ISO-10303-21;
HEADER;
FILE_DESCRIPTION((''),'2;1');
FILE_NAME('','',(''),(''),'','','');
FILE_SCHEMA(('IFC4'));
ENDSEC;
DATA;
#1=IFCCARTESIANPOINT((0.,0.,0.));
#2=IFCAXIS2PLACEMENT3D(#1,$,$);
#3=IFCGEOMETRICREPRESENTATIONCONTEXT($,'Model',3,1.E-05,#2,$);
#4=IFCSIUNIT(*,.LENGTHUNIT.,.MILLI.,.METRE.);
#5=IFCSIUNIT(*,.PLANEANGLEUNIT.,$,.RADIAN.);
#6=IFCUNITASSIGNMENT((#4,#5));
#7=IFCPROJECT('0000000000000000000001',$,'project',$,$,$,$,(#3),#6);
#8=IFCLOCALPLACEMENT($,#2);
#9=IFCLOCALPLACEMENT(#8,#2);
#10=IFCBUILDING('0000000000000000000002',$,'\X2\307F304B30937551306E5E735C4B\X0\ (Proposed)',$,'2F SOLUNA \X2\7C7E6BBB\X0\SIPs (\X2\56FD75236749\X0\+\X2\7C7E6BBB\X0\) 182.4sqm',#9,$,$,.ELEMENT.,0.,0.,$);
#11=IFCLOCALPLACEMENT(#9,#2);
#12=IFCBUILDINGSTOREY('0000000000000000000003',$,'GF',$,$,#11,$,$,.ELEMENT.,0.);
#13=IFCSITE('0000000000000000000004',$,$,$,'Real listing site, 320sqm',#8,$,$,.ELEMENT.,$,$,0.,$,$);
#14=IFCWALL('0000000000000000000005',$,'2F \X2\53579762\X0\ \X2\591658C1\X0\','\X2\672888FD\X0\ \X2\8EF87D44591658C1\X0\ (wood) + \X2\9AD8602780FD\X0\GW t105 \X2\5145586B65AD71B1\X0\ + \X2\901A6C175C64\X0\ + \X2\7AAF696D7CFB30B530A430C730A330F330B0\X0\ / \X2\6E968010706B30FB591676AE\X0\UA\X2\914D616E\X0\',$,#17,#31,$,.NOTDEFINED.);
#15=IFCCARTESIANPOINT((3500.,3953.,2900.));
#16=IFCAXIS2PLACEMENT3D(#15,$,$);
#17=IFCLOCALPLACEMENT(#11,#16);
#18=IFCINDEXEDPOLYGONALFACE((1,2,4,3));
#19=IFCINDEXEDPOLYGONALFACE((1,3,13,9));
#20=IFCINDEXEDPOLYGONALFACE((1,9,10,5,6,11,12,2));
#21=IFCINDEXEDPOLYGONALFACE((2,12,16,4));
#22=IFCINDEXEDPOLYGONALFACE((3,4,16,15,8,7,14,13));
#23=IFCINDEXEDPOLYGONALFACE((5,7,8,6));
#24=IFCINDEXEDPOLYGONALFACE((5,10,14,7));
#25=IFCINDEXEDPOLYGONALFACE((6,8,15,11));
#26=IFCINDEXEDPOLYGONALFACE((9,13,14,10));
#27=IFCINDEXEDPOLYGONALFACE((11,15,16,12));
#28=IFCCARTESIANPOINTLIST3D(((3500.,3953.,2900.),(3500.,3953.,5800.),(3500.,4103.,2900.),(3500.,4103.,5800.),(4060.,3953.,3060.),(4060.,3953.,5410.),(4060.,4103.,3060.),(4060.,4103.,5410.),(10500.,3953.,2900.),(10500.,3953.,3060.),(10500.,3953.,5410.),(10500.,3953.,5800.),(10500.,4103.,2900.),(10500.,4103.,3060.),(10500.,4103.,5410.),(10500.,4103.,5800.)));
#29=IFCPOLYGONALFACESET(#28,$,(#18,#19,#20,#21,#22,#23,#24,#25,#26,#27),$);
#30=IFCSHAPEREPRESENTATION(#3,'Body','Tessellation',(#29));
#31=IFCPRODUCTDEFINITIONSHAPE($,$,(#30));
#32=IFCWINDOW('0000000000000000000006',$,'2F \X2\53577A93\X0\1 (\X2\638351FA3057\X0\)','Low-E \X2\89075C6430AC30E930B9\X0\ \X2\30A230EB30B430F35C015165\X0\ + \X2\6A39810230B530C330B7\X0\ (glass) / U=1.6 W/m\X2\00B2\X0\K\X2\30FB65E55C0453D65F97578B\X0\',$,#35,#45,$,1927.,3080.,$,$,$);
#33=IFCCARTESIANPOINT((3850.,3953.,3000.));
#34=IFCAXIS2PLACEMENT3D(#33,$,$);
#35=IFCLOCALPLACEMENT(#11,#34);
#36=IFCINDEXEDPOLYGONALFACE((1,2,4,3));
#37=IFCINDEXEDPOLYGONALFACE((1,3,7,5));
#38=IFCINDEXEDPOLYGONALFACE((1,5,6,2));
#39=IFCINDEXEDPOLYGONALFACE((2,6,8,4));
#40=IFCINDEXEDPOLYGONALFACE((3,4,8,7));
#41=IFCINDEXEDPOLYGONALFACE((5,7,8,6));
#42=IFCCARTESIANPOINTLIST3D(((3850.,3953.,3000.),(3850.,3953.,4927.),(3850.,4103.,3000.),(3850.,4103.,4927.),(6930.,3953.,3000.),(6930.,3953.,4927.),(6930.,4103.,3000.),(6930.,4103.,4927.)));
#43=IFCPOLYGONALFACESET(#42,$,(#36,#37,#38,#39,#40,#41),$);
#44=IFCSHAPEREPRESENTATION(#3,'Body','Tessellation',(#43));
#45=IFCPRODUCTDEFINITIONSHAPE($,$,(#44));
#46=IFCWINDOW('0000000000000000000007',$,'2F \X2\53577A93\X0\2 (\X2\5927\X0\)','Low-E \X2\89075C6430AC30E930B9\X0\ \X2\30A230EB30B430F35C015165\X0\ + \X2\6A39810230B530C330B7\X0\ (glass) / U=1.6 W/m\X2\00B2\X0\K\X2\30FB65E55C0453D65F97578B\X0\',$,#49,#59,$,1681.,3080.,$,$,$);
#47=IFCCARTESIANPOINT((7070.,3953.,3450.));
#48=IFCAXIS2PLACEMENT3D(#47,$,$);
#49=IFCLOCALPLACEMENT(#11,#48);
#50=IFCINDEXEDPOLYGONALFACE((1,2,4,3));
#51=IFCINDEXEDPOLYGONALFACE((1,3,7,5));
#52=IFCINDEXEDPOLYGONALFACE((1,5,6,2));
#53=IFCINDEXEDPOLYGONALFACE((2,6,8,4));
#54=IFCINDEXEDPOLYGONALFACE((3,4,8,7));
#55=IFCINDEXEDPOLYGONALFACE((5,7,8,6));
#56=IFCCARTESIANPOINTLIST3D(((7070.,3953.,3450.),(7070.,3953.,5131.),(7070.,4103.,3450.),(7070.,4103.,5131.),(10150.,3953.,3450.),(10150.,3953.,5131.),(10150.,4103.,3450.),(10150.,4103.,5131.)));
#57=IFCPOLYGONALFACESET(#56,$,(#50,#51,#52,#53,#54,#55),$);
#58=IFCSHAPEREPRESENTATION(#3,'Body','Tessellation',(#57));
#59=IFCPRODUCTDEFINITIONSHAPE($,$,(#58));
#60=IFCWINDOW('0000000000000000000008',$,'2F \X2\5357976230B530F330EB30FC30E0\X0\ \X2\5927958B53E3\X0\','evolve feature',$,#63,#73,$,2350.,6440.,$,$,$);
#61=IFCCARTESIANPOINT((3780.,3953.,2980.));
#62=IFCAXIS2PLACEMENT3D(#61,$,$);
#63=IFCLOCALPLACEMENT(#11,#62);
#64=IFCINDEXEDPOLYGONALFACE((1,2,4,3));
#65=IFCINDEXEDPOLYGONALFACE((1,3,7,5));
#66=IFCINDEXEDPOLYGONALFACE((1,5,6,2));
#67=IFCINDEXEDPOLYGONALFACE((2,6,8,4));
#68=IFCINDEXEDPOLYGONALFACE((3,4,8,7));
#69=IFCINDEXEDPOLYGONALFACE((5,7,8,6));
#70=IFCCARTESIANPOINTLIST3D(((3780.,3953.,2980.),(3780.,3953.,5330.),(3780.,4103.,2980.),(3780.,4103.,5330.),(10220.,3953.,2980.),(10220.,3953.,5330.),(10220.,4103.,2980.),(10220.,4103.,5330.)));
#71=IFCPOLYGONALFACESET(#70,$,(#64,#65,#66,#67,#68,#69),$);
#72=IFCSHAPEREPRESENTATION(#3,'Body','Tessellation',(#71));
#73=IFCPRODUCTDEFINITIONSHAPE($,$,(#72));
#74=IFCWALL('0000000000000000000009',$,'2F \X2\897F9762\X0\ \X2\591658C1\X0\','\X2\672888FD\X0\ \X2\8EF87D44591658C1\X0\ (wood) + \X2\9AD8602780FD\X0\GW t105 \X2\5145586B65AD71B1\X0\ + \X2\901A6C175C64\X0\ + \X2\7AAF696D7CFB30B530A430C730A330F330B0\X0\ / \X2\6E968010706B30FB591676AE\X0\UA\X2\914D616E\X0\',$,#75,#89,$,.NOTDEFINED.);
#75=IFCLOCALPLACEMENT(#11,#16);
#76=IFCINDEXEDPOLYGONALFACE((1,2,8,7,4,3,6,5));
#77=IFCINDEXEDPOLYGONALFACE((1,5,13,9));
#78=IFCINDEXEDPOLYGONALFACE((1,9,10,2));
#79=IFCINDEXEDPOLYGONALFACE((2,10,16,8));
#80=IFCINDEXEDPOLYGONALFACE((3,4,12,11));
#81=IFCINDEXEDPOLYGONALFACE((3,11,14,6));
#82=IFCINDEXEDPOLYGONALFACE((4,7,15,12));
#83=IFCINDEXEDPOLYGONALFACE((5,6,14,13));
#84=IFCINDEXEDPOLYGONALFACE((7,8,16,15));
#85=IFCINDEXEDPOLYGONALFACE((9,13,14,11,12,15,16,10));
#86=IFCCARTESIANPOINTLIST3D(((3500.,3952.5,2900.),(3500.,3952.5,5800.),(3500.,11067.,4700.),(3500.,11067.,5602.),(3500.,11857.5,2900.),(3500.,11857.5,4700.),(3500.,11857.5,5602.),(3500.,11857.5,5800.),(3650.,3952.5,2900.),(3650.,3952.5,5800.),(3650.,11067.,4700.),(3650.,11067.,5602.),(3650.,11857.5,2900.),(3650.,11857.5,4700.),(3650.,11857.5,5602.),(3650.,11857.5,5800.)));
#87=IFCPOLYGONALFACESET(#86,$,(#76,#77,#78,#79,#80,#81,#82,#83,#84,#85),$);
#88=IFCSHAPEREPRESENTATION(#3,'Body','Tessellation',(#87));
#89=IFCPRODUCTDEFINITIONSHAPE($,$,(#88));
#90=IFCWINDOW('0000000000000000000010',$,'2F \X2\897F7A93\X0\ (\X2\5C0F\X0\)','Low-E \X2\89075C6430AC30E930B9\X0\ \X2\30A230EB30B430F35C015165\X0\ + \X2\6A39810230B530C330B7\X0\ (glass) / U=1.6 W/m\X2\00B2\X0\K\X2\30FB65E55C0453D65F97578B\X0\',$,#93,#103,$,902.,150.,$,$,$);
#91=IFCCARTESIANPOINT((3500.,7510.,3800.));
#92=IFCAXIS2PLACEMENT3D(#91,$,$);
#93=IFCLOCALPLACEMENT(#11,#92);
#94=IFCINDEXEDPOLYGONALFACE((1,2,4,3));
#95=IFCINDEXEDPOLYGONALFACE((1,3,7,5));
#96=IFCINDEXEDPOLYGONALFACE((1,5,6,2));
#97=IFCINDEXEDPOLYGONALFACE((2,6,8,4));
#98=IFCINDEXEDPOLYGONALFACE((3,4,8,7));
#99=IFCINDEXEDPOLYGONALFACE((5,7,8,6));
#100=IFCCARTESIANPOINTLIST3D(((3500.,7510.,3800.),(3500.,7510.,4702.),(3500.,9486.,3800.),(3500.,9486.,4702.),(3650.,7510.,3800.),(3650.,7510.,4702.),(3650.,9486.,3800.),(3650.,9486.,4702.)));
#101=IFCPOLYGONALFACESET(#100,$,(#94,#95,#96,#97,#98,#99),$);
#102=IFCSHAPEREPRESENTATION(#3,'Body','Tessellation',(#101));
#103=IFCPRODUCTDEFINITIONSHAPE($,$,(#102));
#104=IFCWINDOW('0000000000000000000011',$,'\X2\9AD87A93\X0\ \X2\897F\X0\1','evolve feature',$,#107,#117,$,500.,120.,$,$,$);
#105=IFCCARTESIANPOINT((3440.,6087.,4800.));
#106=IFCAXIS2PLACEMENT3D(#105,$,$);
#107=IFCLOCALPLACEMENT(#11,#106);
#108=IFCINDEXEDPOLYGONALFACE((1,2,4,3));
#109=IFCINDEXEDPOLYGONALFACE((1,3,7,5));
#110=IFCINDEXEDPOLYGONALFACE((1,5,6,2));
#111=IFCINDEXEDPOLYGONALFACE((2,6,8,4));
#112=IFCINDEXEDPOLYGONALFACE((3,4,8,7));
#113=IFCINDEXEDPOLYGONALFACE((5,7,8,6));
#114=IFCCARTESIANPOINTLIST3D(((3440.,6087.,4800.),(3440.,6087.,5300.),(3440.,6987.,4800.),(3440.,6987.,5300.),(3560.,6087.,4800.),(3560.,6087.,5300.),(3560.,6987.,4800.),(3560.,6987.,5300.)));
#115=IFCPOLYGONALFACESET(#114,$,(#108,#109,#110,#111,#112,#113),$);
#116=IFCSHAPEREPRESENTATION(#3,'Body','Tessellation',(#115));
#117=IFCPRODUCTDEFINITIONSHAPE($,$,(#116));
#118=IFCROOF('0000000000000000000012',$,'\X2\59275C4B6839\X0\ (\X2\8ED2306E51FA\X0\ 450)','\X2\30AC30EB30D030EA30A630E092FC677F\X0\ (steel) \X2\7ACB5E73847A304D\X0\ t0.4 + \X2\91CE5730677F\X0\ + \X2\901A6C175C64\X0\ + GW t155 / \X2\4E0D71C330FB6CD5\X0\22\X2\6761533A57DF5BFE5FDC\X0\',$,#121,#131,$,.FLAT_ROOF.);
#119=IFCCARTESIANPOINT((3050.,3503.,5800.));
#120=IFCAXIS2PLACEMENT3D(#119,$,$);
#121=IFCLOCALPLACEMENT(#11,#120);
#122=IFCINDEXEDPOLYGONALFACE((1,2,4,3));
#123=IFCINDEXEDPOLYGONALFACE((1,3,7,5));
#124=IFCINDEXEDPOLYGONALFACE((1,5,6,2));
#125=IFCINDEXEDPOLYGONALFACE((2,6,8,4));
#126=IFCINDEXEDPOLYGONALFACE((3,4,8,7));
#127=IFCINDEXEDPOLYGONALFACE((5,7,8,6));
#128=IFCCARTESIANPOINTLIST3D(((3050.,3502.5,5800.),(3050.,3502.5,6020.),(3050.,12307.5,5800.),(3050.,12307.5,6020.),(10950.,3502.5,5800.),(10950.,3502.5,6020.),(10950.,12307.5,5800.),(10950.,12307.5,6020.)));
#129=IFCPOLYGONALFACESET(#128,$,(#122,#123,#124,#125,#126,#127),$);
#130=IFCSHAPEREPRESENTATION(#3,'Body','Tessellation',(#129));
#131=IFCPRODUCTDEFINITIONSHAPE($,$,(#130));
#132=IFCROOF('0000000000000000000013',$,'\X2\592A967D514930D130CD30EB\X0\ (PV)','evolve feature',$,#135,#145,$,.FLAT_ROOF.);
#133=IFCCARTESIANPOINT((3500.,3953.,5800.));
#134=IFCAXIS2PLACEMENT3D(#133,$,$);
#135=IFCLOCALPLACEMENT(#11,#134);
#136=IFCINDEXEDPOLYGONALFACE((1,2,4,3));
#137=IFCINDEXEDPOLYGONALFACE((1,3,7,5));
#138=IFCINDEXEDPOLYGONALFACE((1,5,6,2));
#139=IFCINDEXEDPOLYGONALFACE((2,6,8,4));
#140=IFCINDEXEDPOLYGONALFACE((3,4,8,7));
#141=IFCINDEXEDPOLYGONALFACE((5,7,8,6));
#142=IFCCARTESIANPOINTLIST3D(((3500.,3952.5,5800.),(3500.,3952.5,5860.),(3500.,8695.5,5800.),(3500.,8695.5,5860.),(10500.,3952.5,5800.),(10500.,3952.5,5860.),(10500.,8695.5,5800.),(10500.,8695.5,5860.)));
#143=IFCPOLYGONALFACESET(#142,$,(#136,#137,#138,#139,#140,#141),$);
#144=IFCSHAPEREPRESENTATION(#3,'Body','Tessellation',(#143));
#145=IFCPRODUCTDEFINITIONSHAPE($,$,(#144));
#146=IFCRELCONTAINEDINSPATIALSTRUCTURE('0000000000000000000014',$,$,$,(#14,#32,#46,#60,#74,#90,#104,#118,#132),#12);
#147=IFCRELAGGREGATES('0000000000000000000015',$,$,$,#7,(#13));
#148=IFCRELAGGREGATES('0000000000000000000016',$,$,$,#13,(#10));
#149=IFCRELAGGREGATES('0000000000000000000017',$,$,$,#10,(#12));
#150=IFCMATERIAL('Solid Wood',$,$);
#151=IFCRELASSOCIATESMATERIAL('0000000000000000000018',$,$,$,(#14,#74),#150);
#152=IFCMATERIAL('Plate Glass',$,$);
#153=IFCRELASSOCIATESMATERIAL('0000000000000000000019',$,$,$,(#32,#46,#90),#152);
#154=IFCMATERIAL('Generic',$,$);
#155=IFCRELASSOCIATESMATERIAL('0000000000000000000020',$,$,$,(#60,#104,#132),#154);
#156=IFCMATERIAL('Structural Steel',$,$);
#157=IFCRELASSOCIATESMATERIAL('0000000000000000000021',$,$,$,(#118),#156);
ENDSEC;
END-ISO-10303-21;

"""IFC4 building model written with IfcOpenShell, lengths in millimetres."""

from ifc_helpers import new_model, si_unit, frame, frame_2d, origin, place, context, project, spatial, rectangle, extrude, material, element, fill, save


model = new_model("IFC4")

# Units and contexts
model_context = context("Model", 3, precision=1e-05, world=origin())
ifc_project = project(units=[si_unit("LENGTHUNIT", "METRE", prefix="MILLI"), si_unit("PLANEANGLEUNIT", "RADIAN")], contexts=[model_context])

# Site, building, storey
site_placement = place(None, origin())
site = spatial("IfcSite", under=ifc_project, at=site_placement, ObjectType="Real listing site, 320sqm", CompositionType="ELEMENT", RefElevation=0.0)
building_placement = place(site_placement, origin())
building = spatial("IfcBuilding", under=site, at=building_placement, Name="みかん畑の平屋 (Proposed)", ObjectType="2F SOLUNA 籾殻SIPs (国産杉+籾殻) 182.4sqm", CompositionType="ELEMENT", ElevationOfRefHeight=0.0, ElevationOfTerrain=0.0)
storey_placement = place(building_placement, origin())
storey = spatial("IfcBuildingStorey", under=building, at=storey_placement, Name="GF", CompositionType="ELEMENT", Elevation=0.0)

# Shared definitions
ifc_material_1 = material(Name="Solid Wood")
ifc_material_2 = material(Name="Generic")

# Shared definitions
ifc_material_3 = material(Name="Plate Glass")

# Walls, openings, windows
wall_1_placement = place(storey_placement, frame((3500.0, 3953.0, 2900.0)))
wall_1 = element("IfcWall", 1, at=wall_1_placement, inside=storey, material=ifc_material_1, Name="2F 南面 外壁", Description="木製 軸組外壁 (wood) + 高性能GW t105 充填断熱 + 通気層 + 窯業系サイディング / 準耐火・外皮UA配慮", PredefinedType="NOTDEFINED", context=model_context, shape_type="SweptSolid", body=[
    extrude(rectangle(XDim=7000.0, YDim=150.0, at=frame_2d((3500.0, 75.0))), frame((3500.0, 3953.0, 2900.0)), (0.0, 0.0, 1.0), 2900.0),
])
opening_1_placement = place(storey_placement, frame((3850.0, 3953.0, 3000.0)))
opening_1 = element("IfcOpeningElement", 2, at=opening_1_placement, cuts=wall_1, PredefinedType="NOTDEFINED", context=model_context, shape_type="SweptSolid", body=[
    extrude(rectangle(XDim=3080.0, YDim=150.0, at=frame_2d((1540.0, 75.0))), frame((3850.0, 3953.0, 3000.0)), (0.0, 0.0, 1.0), 1927.0),
])
opening_2_placement = place(storey_placement, frame((7070.0, 3953.0, 3450.0)))
opening_2 = element("IfcOpeningElement", 3, at=opening_2_placement, cuts=wall_1, PredefinedType="NOTDEFINED", context=model_context, shape_type="SweptSolid", body=[
    extrude(rectangle(XDim=3080.0, YDim=150.0, at=frame_2d((1540.0, 75.0))), frame((7070.0, 3953.0, 3450.0)), (0.0, 0.0, 1.0), 1681.0),
])
opening_3_placement = place(storey_placement, frame((3780.0, 3953.0, 2980.0)))
opening_3 = element("IfcOpeningElement", 4, at=opening_3_placement, cuts=wall_1, PredefinedType="NOTDEFINED", context=model_context, shape_type="SweptSolid", body=[
    extrude(rectangle(XDim=6440.0, YDim=150.0, at=frame_2d((3220.0, 75.0))), frame((3780.0, 3953.0, 2980.0)), (0.0, 0.0, 1.0), 2350.0),
])
window_1_placement = place(storey_placement, frame((3850.0, 3953.0, 3000.0)))
window_1 = element("IfcWindow", 5, at=window_1_placement, inside=storey, material=ifc_material_3, Name="2F 南窓1 (掃出し)", Description="Low-E 複層ガラス アルゴン封入 + 樹脂サッシ (glass) / U=1.6 W/m²K・日射取得型", OverallHeight=1927.0, OverallWidth=3080.0, context=model_context, shape_type="SweptSolid", body=[
    extrude(rectangle(XDim=3080.0, YDim=150.0, at=frame_2d((1540.0, 75.0))), frame((3850.0, 3953.0, 3000.0)), (0.0, 0.0, 1.0), 1927.0),
])
fill(opening_1, window_1)
window_2_placement = place(storey_placement, frame((7070.0, 3953.0, 3450.0)))
window_2 = element("IfcWindow", 6, at=window_2_placement, inside=storey, material=ifc_material_3, Name="2F 南窓2 (大)", Description="Low-E 複層ガラス アルゴン封入 + 樹脂サッシ (glass) / U=1.6 W/m²K・日射取得型", OverallHeight=1681.0, OverallWidth=3080.0, context=model_context, shape_type="SweptSolid", body=[
    extrude(rectangle(XDim=3080.0, YDim=150.0, at=frame_2d((1540.0, 75.0))), frame((7070.0, 3953.0, 3450.0)), (0.0, 0.0, 1.0), 1681.0),
])
fill(opening_2, window_2)
window_3_placement = place(storey_placement, frame((3780.0, 3953.0, 2980.0)))
window_3 = element("IfcWindow", 7, at=window_3_placement, inside=storey, material=ifc_material_2, Name="2F 南面サンルーム 大開口", Description="evolve feature", OverallHeight=2350.0, OverallWidth=6440.0, context=model_context, shape_type="SweptSolid", body=[
    extrude(rectangle(XDim=6440.0, YDim=150.0, at=frame_2d((3220.0, 75.0))), frame((3780.0, 3953.0, 2980.0)), (0.0, 0.0, 1.0), 2350.0),
])
fill(opening_3, window_3)
wall_2_placement = place(storey_placement, frame((3500.0, 3953.0, 2900.0)))
wall_2 = element("IfcWall", 8, at=wall_2_placement, inside=storey, material=ifc_material_1, Name="2F 西面 外壁", Description="木製 軸組外壁 (wood) + 高性能GW t105 充填断熱 + 通気層 + 窯業系サイディング / 準耐火・外皮UA配慮", PredefinedType="NOTDEFINED", context=model_context, shape_type="SweptSolid", body=[
    extrude(rectangle(XDim=150.0, YDim=7905.0, at=frame_2d((75.0, 3952.0))), frame((3500.0, 3953.0, 2900.0)), (0.0, 0.0, 1.0), 2900.0),
])
opening_4_placement = place(storey_placement, frame((3500.0, 7510.0, 3800.0)))
opening_4 = element("IfcOpeningElement", 9, at=opening_4_placement, cuts=wall_2, PredefinedType="NOTDEFINED", context=model_context, shape_type="SweptSolid", body=[
    extrude(rectangle(XDim=150.0, YDim=1976.0, at=frame_2d((75.0, 988.0))), frame((3500.0, 7510.0, 3800.0)), (0.0, 0.0, 1.0), 902.0),
])
opening_5_placement = place(storey_placement, frame((3440.0, 6087.0, 4800.0)))
opening_5 = element("IfcOpeningElement", 10, at=opening_5_placement, cuts=wall_2, PredefinedType="NOTDEFINED", context=model_context, shape_type="SweptSolid", body=[
    extrude(rectangle(XDim=120.0, YDim=900.0, at=frame_2d((60.0, 450.0))), frame((3440.0, 6087.0, 4800.0)), (0.0, 0.0, 1.0), 500.0),
])
window_4_placement = place(storey_placement, frame((3500.0, 7510.0, 3800.0)))
window_4 = element("IfcWindow", 11, at=window_4_placement, inside=storey, material=ifc_material_3, Name="2F 西窓 (小)", Description="Low-E 複層ガラス アルゴン封入 + 樹脂サッシ (glass) / U=1.6 W/m²K・日射取得型", OverallHeight=902.0, OverallWidth=150.0, context=model_context, shape_type="SweptSolid", body=[
    extrude(rectangle(XDim=150.0, YDim=1976.0, at=frame_2d((75.0, 988.0))), frame((3500.0, 7510.0, 3800.0)), (0.0, 0.0, 1.0), 902.0),
])
fill(opening_4, window_4)
window_5_placement = place(storey_placement, frame((3440.0, 6087.0, 4800.0)))
window_5 = element("IfcWindow", 12, at=window_5_placement, inside=storey, material=ifc_material_2, Name="高窓 西1", Description="evolve feature", OverallHeight=500.0, OverallWidth=120.0, context=model_context, shape_type="SweptSolid", body=[
    extrude(rectangle(XDim=120.0, YDim=900.0, at=frame_2d((60.0, 450.0))), frame((3440.0, 6087.0, 4800.0)), (0.0, 0.0, 1.0), 500.0),
])
fill(opening_5, window_5)

# Roofs
ifc_material_4 = material(Name="Structural Steel")
roof_1_placement = place(storey_placement, frame((3050.0, 3503.0, 5800.0)))
element("IfcRoof", 13, at=roof_1_placement, inside=storey, material=ifc_material_4, Name="大屋根 (軒の出 450)", Description="ガルバリウム鋼板 (steel) 立平葺き t0.4 + 野地板 + 通気層 + GW t155 / 不燃・法22条区域対応", PredefinedType="FLAT_ROOF", context=model_context, shape_type="SweptSolid", body=[
    extrude(rectangle(XDim=7900.0, YDim=8805.0, at=frame_2d((3950.0, 4402.0))), frame((3050.0, 3503.0, 5800.0)), (0.0, 0.0, 1.0), 220.0),
])
roof_2_placement = place(storey_placement, frame((3500.0, 3953.0, 5800.0)))
element("IfcRoof", 14, at=roof_2_placement, inside=storey, material=ifc_material_2, Name="太陽光パネル (PV)", Description="evolve feature", PredefinedType="FLAT_ROOF", context=model_context, shape_type="SweptSolid", body=[
    extrude(rectangle(XDim=7000.0, YDim=4743.0, at=frame_2d((3500.0, 2371.0))), frame((3500.0, 3953.0, 5800.0)), (0.0, 0.0, 1.0), 60.0),
])

save(model, "model.ifc")
